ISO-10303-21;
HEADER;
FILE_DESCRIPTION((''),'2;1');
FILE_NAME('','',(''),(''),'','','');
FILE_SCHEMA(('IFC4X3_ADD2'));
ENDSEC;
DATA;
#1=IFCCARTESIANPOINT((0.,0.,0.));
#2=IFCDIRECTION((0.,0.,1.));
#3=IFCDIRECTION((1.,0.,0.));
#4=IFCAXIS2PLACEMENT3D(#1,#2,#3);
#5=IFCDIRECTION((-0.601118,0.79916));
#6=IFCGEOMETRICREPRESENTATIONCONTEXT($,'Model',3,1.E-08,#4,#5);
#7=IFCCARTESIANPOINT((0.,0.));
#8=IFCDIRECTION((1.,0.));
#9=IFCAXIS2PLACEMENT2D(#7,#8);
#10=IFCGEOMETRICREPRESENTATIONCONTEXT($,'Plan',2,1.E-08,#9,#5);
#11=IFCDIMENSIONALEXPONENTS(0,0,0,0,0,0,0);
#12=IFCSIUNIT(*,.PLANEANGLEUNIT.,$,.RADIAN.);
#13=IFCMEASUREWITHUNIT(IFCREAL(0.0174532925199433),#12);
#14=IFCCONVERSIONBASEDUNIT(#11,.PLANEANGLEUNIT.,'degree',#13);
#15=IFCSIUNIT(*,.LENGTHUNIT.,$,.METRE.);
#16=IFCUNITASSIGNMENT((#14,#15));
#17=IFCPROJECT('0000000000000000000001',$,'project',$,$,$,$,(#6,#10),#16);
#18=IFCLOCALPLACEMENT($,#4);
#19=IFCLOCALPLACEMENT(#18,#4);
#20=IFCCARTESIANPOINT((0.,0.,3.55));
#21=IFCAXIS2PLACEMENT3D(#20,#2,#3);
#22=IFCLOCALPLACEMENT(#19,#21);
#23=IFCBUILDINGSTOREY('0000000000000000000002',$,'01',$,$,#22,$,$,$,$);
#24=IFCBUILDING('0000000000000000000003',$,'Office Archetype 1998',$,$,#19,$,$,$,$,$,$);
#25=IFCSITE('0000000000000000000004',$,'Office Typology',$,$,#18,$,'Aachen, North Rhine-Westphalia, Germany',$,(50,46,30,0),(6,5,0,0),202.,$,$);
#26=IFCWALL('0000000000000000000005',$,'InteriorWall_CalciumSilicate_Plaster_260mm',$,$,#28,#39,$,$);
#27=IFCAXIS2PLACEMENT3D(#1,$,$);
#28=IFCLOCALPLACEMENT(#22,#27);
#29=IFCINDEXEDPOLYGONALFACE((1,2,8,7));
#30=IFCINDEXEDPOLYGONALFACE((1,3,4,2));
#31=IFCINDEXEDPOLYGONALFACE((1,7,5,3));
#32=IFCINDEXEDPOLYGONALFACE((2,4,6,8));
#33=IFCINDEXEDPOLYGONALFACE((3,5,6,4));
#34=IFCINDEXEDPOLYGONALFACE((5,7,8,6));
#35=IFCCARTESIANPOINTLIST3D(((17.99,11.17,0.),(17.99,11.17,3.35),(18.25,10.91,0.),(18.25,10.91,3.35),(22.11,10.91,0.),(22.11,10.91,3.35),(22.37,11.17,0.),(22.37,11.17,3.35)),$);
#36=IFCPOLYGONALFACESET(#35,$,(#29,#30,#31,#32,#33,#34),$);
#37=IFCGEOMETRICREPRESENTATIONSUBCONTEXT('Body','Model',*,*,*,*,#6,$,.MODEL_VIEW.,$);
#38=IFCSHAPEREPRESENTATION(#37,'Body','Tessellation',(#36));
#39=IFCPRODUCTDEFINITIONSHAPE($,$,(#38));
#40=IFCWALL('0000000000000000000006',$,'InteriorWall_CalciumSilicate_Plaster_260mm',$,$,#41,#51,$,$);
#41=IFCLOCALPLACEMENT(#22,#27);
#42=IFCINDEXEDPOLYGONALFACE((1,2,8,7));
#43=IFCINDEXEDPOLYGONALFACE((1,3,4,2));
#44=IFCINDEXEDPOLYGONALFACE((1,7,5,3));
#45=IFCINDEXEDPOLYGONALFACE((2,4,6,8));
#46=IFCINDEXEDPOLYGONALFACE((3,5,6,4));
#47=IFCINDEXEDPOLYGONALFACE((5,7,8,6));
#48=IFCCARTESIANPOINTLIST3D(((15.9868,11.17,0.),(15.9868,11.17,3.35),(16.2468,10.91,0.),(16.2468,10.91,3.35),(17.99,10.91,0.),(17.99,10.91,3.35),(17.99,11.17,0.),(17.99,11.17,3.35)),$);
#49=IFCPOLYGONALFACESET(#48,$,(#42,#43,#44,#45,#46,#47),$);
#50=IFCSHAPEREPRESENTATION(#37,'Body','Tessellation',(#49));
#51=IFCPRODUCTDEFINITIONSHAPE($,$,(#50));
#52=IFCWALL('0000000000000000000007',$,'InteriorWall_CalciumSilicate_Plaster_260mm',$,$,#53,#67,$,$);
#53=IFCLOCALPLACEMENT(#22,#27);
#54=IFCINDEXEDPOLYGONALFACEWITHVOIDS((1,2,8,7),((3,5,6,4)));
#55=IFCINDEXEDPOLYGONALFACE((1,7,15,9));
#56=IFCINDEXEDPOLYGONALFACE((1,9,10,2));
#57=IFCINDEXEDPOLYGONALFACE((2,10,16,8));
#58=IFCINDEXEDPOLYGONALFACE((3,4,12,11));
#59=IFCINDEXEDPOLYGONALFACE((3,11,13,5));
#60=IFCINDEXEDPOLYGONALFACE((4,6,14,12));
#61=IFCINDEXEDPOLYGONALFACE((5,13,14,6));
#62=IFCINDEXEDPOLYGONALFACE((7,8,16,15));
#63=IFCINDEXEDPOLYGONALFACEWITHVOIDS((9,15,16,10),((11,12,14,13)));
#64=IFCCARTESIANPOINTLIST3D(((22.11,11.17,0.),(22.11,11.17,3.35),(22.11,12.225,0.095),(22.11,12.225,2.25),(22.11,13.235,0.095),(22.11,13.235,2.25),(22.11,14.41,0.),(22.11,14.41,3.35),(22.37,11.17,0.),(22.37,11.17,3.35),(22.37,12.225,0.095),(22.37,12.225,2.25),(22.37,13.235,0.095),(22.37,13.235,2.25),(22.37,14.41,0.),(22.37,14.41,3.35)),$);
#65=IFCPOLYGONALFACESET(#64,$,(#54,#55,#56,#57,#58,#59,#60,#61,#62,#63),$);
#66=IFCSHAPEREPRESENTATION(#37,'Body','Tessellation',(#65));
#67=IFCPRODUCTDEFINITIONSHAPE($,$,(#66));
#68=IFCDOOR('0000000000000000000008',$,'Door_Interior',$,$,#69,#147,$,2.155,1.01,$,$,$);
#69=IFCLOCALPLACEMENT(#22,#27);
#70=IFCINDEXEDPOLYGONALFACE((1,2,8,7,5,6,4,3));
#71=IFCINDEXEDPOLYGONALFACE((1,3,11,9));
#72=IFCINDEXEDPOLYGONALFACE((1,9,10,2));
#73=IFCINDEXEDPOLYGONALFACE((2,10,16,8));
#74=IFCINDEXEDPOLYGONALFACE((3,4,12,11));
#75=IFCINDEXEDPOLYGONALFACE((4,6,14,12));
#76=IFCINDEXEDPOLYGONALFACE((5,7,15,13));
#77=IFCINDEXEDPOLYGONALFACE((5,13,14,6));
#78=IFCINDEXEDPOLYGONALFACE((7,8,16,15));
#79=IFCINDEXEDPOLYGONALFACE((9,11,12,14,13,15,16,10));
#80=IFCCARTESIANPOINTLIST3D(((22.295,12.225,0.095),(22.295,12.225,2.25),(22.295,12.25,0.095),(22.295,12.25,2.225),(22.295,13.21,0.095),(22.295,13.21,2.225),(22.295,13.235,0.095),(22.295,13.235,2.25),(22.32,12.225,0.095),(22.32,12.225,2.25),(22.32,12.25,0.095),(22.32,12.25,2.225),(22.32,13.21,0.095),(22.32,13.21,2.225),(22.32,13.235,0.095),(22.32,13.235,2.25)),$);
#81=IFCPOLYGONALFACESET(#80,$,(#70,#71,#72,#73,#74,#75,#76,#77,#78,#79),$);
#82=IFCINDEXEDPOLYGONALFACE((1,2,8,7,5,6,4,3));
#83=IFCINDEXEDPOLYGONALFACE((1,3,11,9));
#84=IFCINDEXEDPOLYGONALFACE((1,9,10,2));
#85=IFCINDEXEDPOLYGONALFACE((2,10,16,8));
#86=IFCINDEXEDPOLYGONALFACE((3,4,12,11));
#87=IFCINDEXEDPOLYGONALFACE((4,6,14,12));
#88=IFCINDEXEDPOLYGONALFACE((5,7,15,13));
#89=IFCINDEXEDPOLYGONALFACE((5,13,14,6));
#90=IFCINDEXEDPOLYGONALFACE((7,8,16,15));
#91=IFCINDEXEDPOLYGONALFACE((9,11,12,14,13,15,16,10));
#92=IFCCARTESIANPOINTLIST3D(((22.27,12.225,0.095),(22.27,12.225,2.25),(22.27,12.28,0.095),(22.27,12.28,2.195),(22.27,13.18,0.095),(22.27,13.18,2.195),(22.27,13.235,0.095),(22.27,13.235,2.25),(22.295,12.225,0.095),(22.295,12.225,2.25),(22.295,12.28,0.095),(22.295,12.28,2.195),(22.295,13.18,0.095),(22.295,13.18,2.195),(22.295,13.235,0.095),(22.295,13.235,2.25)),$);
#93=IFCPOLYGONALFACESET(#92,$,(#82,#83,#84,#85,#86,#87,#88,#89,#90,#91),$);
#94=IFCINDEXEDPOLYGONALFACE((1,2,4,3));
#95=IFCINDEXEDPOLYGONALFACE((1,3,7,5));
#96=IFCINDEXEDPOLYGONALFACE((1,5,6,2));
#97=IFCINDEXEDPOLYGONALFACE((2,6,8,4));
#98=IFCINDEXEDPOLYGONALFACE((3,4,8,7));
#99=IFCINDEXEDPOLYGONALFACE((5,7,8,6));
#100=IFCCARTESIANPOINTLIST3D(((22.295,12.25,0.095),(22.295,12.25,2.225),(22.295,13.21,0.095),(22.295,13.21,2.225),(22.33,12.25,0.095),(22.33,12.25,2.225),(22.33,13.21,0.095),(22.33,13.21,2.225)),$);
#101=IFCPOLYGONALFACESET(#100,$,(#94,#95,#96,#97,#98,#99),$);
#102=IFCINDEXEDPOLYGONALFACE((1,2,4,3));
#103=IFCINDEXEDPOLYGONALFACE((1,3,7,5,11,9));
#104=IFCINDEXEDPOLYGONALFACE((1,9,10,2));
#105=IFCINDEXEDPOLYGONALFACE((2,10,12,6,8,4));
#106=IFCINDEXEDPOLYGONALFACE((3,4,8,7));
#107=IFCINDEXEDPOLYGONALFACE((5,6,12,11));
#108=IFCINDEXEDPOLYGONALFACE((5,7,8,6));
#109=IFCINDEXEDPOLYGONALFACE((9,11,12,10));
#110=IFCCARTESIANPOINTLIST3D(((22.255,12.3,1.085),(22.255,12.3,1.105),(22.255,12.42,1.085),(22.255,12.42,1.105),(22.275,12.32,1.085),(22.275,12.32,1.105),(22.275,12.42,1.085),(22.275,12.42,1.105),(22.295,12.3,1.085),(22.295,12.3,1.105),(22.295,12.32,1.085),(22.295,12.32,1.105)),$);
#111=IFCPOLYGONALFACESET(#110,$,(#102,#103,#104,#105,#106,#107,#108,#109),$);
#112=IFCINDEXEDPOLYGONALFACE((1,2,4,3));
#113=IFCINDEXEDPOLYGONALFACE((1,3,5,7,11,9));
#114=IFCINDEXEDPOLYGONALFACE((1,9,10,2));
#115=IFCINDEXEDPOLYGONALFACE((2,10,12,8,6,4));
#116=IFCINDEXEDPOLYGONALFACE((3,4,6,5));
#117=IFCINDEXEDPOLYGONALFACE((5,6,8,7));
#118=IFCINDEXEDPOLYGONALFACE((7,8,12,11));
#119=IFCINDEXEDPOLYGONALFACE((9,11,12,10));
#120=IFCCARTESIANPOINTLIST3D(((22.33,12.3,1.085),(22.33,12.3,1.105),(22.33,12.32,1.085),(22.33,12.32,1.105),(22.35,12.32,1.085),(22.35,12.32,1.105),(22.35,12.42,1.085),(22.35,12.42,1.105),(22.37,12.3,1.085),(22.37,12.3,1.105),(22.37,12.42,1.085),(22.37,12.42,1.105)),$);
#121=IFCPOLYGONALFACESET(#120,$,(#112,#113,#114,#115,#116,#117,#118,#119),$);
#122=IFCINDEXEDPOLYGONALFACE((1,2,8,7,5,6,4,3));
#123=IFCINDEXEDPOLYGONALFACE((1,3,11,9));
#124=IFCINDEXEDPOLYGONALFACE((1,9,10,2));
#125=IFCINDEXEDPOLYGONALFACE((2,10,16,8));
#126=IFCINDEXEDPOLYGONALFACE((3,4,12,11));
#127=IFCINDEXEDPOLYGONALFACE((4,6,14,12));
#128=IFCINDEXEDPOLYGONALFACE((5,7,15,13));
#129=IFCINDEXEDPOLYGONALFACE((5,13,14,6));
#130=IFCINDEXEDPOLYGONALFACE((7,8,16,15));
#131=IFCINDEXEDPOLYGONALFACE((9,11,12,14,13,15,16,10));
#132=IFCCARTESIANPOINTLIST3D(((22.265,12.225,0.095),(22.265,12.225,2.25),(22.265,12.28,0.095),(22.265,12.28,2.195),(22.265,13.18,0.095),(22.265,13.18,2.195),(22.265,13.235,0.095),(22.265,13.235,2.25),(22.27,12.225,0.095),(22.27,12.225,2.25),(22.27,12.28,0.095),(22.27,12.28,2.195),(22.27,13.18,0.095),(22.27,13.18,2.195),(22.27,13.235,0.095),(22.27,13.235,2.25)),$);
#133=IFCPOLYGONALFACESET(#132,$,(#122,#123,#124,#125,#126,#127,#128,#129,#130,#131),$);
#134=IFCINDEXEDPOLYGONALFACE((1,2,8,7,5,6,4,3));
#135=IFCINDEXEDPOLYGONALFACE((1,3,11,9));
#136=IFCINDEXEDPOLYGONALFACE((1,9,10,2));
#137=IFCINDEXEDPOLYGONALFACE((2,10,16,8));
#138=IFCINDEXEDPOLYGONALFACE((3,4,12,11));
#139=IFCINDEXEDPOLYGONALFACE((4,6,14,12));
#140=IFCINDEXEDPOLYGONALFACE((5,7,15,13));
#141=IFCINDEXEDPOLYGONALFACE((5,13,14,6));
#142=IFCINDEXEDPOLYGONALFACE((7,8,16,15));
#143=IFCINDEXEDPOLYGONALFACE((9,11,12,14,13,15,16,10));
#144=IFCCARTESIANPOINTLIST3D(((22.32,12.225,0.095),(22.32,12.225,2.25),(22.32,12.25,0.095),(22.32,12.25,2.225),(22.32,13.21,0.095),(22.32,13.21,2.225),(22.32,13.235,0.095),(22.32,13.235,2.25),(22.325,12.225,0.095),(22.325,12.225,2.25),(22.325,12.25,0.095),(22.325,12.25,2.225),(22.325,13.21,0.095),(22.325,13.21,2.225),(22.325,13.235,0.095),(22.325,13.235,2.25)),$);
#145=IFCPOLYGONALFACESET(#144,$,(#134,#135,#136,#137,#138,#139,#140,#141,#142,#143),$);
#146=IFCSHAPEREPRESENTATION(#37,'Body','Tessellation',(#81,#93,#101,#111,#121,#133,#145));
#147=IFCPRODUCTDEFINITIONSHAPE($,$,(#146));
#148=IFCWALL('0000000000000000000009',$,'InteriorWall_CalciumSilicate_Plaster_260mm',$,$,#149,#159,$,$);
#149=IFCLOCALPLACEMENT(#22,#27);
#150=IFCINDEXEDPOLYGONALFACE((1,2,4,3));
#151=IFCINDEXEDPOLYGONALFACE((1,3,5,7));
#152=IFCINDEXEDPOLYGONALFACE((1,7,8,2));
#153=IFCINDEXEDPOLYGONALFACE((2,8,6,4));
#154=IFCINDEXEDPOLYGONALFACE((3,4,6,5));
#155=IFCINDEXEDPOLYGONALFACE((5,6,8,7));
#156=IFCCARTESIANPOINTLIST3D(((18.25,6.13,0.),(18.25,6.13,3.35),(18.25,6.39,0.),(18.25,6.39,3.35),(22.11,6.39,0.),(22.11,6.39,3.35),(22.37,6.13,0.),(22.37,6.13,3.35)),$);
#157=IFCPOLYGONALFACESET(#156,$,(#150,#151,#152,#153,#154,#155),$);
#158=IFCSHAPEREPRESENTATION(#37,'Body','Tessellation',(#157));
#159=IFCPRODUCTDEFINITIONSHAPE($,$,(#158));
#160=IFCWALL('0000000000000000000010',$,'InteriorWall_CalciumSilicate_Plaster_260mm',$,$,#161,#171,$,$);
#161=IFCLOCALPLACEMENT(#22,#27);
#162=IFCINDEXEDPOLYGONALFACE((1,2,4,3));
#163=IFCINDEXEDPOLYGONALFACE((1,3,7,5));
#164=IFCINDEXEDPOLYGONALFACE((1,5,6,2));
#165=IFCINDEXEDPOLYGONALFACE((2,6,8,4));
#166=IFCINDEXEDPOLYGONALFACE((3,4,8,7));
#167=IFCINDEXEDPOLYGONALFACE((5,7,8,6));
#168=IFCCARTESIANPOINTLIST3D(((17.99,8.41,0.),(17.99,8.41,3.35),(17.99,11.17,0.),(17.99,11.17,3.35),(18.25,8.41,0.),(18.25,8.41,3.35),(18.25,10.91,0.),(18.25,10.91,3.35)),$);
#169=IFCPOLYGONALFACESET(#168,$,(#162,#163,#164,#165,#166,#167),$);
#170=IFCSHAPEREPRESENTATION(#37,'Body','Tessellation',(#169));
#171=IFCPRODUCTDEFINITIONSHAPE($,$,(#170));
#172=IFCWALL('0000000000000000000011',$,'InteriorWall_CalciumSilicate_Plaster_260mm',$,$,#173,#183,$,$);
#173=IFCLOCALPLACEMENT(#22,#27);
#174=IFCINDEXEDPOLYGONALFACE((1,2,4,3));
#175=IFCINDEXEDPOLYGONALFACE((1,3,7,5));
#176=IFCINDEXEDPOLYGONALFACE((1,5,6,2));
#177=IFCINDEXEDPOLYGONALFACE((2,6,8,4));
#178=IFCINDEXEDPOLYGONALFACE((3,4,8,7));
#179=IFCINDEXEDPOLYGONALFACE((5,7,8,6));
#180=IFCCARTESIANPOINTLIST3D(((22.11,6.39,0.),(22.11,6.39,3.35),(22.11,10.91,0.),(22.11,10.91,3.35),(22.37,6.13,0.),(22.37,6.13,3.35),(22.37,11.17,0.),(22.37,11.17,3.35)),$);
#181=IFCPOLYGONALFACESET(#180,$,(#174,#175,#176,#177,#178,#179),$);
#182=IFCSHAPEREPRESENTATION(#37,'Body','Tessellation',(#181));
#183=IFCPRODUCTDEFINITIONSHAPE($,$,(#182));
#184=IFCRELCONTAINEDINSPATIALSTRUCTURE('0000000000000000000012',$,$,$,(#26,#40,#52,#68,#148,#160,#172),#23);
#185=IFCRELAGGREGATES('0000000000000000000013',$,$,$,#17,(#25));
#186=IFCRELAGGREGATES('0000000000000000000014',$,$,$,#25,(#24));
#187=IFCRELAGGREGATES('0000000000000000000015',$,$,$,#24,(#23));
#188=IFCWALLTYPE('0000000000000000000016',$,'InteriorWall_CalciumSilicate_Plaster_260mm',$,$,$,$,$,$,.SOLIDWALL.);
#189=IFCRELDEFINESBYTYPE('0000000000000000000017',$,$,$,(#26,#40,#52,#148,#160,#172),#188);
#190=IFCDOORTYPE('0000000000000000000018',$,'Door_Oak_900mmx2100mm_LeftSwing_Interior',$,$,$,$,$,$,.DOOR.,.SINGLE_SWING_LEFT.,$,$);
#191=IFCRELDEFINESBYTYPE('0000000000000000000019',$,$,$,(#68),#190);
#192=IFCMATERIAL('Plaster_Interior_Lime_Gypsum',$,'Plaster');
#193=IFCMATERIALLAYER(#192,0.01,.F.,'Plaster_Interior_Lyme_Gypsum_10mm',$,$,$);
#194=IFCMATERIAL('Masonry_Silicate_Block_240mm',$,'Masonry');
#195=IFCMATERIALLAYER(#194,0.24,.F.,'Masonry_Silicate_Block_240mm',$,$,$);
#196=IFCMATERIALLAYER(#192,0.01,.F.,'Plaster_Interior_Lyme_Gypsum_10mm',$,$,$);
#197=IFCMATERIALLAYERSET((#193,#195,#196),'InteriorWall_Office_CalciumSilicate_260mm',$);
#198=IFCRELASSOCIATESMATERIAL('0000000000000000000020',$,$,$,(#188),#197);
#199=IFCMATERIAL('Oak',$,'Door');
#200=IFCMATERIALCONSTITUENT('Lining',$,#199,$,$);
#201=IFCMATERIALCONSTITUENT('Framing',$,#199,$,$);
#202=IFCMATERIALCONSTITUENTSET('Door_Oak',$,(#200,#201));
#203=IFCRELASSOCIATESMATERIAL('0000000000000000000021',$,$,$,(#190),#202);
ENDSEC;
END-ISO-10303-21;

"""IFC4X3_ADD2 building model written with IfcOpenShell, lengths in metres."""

from ifc_helpers import new_model, entity, si_unit, converted_unit, direction, frame, origin_with_axes, origin_2d_with_axis, place, context, subcontext, project, spatial, line, indexed_curve, outline, extrude, source, transform, mapped, material, layer, layer_set, constituent, constituent_set, type_object, type_shapes, element, fill, save


model = new_model("IFC4X3_ADD2")

# Units and contexts
model_context = context("Model", 3, precision=1e-08, world=origin_with_axes(), true_north=direction((-0.601118, 0.79916)))
plan_context = context("Plan", 2, precision=1e-08, world=origin_2d_with_axis(), true_north=direction((-0.601118, 0.79916)))
body_context = subcontext(model_context, "Body", "Model", "MODEL_VIEW")
ifc_project = project(units=[converted_unit("PLANEANGLEUNIT", "degree", entity("IfcReal", 0.0174532925199433), si_unit("PLANEANGLEUNIT", "RADIAN"), dimensions=[0, 0, 0, 0, 0, 0, 0]), si_unit("LENGTHUNIT", "METRE")], contexts=[model_context, plan_context])

# Site, building, storey
site_placement = place(None, origin_with_axes())
site = spatial("IfcSite", under=ifc_project, at=site_placement, Name="Office Typology", LongName="Aachen, North Rhine-Westphalia, Germany", RefLatitude=(50, 46, 30, 0), RefLongitude=(6, 5, 0, 0), RefElevation=202.0)
building_placement = place(site_placement, origin_with_axes())
building = spatial("IfcBuilding", under=site, at=building_placement, Name="Office Archetype 1998")
storey_placement = place(building_placement, frame((0.0, 0.0, 3.55), z_axis=(0.0, 0.0, 1.0), x_axis=(1.0, 0.0, 0.0)))
storey = spatial("IfcBuildingStorey", under=building, at=storey_placement, Name="01")

# Shared definitions
ifc_material_1 = material(Name="Plaster_Interior_Lime_Gypsum", Category="Plaster")
ifc_layer_1 = layer(ifc_material_1, 0.01, ventilated=False, Name="Plaster_Interior_Lyme_Gypsum_10mm")
ifc_material_2 = material(Name="Masonry_Silicate_Block_240mm", Category="Masonry")
ifc_layer_2 = layer(ifc_material_2, 0.24, ventilated=False, Name="Masonry_Silicate_Block_240mm")
ifc_layer_3 = layer(ifc_material_1, 0.01, ventilated=False, Name="Plaster_Interior_Lyme_Gypsum_10mm")
ifc_layer_set_1 = layer_set([ifc_layer_1, ifc_layer_2, ifc_layer_3], Name="InteriorWall_Office_CalciumSilicate_260mm")
wall_type_1 = type_object("IfcWallType", Name="InteriorWall_CalciumSilicate_Plaster_260mm", PredefinedType="SOLIDWALL", material=ifc_layer_set_1)
ifc_material_3 = material(Name="Oak", Category="Door")

# Walls
wall_1_placement = place(storey_placement, frame((22.37, 11.17, 0.0), z_axis=(0.0, 0.0, 1.0), x_axis=(-1.0, 0.0, 0.0)))
element("IfcWall", 1, at=wall_1_placement, inside=storey, type_object=wall_type_1, Name="InteriorWall_CalciumSilicate_Plaster_260mm", context=body_context, shape_type="SweptSolid", body=[
    extrude(outline(indexed_curve([(0.0, 0.0), (0.26, 0.26), (4.12, 0.26), (4.38, 0.0)], segments=[line(1, 2, 3, 4, 1)])), origin_with_axes(), (0.0, 0.0, 1.0), 3.35),
])
wall_2_placement = place(storey_placement, frame((17.99, 11.17, 0.0), z_axis=(0.0, 0.0, 1.0), x_axis=(-1.0, 0.0, 0.0)))
element("IfcWall", 2, at=wall_2_placement, inside=storey, type_object=wall_type_1, Name="InteriorWall_CalciumSilicate_Plaster_260mm", context=body_context, shape_type="SweptSolid", body=[
    extrude(outline(indexed_curve([(0.0, 0.0), (0.0, 0.26), (1.7432, 0.26), (2.0032, 0.0)], segments=[line(1, 2, 3, 4, 1)])), origin_with_axes(), (0.0, 0.0, 1.0), 3.35),
])

# Wall, opening, door
wall_3_placement = place(storey_placement, frame((22.37, 11.17, 0.0), z_axis=(0.0, 0.0, 1.0), x_axis=(0.0, 1.0, 0.0)))
wall_3 = element("IfcWall", 3, at=wall_3_placement, inside=storey, type_object=wall_type_1, Name="InteriorWall_CalciumSilicate_Plaster_260mm", context=body_context, shape_type="SweptSolid", body=[
    extrude(outline(indexed_curve([(0.0, 0.0), (0.0, 0.26), (3.24, 0.26), (3.24, 0.0)], segments=[line(1, 2, 3, 4, 1)])), origin_with_axes(), (0.0, 0.0, 1.0), 3.35),
])
shared_shape_1 = source(origin_with_axes(), body_context, "Body", "SweptSolid", [
    extrude(outline(indexed_curve([(0.0, 2.155), (1.01, 2.155), (1.01, 0.0), (0.0, 0.0), (0.0, 2.155)])), frame((0.0, -0.015, 0.0), z_axis=(0.0, -1.0, 0.0), x_axis=(1.0, 0.0, 0.0)), (0.0, 0.0, -1.0), 0.26),
])
opening_1_placement = place(wall_3_placement, frame((2.065, 0.245, 0.095), z_axis=(0.0, 0.0, 1.0), x_axis=(-1.0, 0.0, 0.0)))
opening_1 = element("IfcOpeningElement", 4, at=opening_1_placement, cuts=wall_3, PredefinedType="OPENING", context=body_context, shape_type="MappedRepresentation", body=[
    mapped(shared_shape_1, transform((0.0, 0.0, 0.0), x_axis=(1.0, 0.0, 0.0), y_axis=(0.0, 1.0, 0.0), z_axis=(0.0, 0.0, 1.0), scale=1.0)),
])
ifc_constituent_1 = constituent(ifc_material_3, Name="Lining")
ifc_constituent_2 = constituent(ifc_material_3, Name="Framing")
ifc_constituent_set_1 = constituent_set(constituents=[ifc_constituent_1, ifc_constituent_2], Name="Door_Oak")
door_type_1 = type_object("IfcDoorType", Name="Door_Oak_900mmx2100mm_LeftSwing_Interior", OperationType="SINGLE_SWING_LEFT", PredefinedType="DOOR", material=ifc_constituent_set_1)
shared_shape_2 = source(origin_with_axes(), body_context, "Body", "SweptSolid", [
    extrude(outline(indexed_curve([(0.0, 0.0), (0.0, 2.155), (1.01, 2.155), (1.01, 0.0), (0.985, 0.0), (0.985, 2.13), (0.025, 2.13), (0.025, 0.0)], segments=[line(1, 2, 3, 4, 5, 6, 7, 8, 1)])), frame((0.0, 0.025, 0.0), z_axis=(0.0, -1.0, 0.0), x_axis=(1.0, 0.0, 0.0)), (0.0, 0.0, -1.0), 0.025),
    extrude(outline(indexed_curve([(0.0, 0.0), (0.0, 2.155), (1.01, 2.155), (1.01, 0.0), (0.955, 0.0), (0.955, 2.1), (0.055, 2.1), (0.055, 0.0)], segments=[line(1, 2, 3, 4, 5, 6, 7, 8, 1)])), frame((0.0, 0.0, 0.0), z_axis=(0.0, -1.0, 0.0), x_axis=(1.0, 0.0, 0.0)), (0.0, 0.0, -1.0), 0.025),
    extrude(outline(indexed_curve([(0.0, 0.0), (0.96, 0.0), (0.96, 0.035), (0.0, 0.035)], segments=[line(1, 2, 3, 4, 1)])), frame((0.025, 0.025, 0.0), z_axis=(0.0, 0.0, 1.0), x_axis=(1.0, 0.0, 0.0)), (0.0, 0.0, 1.0), 2.13),
    extrude(outline(indexed_curve([(0.0, 0.0), (0.0, -0.04), (-0.12, -0.04), (-0.12, -0.02), (-0.02, -0.02), (-0.02, 0.0)], segments=[line(1, 2, 3, 4, 5, 6, 1)])), frame((0.935, 0.025, 0.99), z_axis=(0.0, 0.0, 1.0), x_axis=(1.0, 0.0, 0.0)), (0.0, 0.0, 1.0), 0.02),
    extrude(outline(indexed_curve([(0.0, 0.0), (0.0, 0.04), (-0.12, 0.04), (-0.12, 0.02), (-0.02, 0.02), (-0.02, 0.0)], segments=[line(1, 2, 3, 4, 5, 6, 1)])), frame((0.935, 0.06, 0.99), z_axis=(0.0, 0.0, 1.0), x_axis=(1.0, 0.0, 0.0)), (0.0, 0.0, 1.0), 0.02),
    extrude(outline(indexed_curve([(0.0, 0.0), (0.0, 2.155), (1.01, 2.155), (1.01, 0.0), (0.955, 0.0), (0.955, 2.1), (0.055, 2.1), (0.055, 0.0)], segments=[line(1, 2, 3, 4, 5, 6, 7, 8, 1)])), frame((0.0, -0.005, 0.0), z_axis=(0.0, -1.0, 0.0), x_axis=(1.0, 0.0, 0.0)), (0.0, 0.0, -1.0), 0.005),
    extrude(outline(indexed_curve([(0.0, 0.0), (0.0, 2.155), (1.01, 2.155), (1.01, 0.0), (0.985, 0.0), (0.985, 2.13), (0.025, 2.13), (0.025, 0.0)], segments=[line(1, 2, 3, 4, 5, 6, 7, 8, 1)])), frame((0.0, 0.05, 0.0), z_axis=(0.0, -1.0, 0.0), x_axis=(1.0, 0.0, 0.0)), (0.0, 0.0, -1.0), 0.005),
])
type_shapes(door_type_1, [shared_shape_2])
door_1_placement = place(opening_1_placement, frame((0.0, 0.145, 0.0), z_axis=(0.0, 0.0, 1.0), x_axis=(1.0, 0.0, 0.0)))
door_1 = element("IfcDoor", 5, at=door_1_placement, inside=storey, type_object=door_type_1, Name="Door_Interior", OverallHeight=2.155, OverallWidth=1.01, context=body_context, shape_type="MappedRepresentation", body=[
    mapped(shared_shape_2, transform((0.0, 0.0, 0.0), x_axis=(1.0, 0.0, 0.0), y_axis=(0.0, 1.0, 0.0), z_axis=(0.0, 0.0, 1.0), scale=1.0)),
])
fill(opening_1, door_1)

# Walls
wall_4_placement = place(storey_placement, frame((18.25, 6.13, 0.0), z_axis=(0.0, 0.0, 1.0), x_axis=(1.0, 0.0, 0.0)))
element("IfcWall", 6, at=wall_4_placement, inside=storey, type_object=wall_type_1, Name="InteriorWall_CalciumSilicate_Plaster_260mm", context=body_context, shape_type="SweptSolid", body=[
    extrude(outline(indexed_curve([(0.0, 0.0), (0.0, 0.26), (3.86, 0.26), (4.12, 0.0)], segments=[line(1, 2, 3, 4, 1)])), origin_with_axes(), (0.0, 0.0, 1.0), 3.35),
])
wall_5_placement = place(storey_placement, frame((17.99, 11.17, 0.0), z_axis=(0.0, 0.0, 1.0), x_axis=(0.0, -1.0, 0.0)))
element("IfcWall", 7, at=wall_5_placement, inside=storey, type_object=wall_type_1, Name="InteriorWall_CalciumSilicate_Plaster_260mm", context=body_context, shape_type="SweptSolid", body=[
    extrude(outline(indexed_curve([(0.0, 0.0), (0.26, 0.26), (2.76, 0.26), (2.76, 0.0)], segments=[line(1, 2, 3, 4, 1)])), origin_with_axes(), (0.0, 0.0, 1.0), 3.35),
])
wall_6_placement = place(storey_placement, frame((22.37, 6.13, 0.0), z_axis=(0.0, 0.0, 1.0), x_axis=(0.0, 1.0, 0.0)))
element("IfcWall", 8, at=wall_6_placement, inside=storey, type_object=wall_type_1, Name="InteriorWall_CalciumSilicate_Plaster_260mm", context=body_context, shape_type="SweptSolid", body=[
    extrude(outline(indexed_curve([(0.0, 0.0), (0.26, 0.26), (4.78, 0.26), (5.04, 0.0)], segments=[line(1, 2, 3, 4, 1)])), origin_with_axes(), (0.0, 0.0, 1.0), 3.35),
])

save(model, "model.ifc")
